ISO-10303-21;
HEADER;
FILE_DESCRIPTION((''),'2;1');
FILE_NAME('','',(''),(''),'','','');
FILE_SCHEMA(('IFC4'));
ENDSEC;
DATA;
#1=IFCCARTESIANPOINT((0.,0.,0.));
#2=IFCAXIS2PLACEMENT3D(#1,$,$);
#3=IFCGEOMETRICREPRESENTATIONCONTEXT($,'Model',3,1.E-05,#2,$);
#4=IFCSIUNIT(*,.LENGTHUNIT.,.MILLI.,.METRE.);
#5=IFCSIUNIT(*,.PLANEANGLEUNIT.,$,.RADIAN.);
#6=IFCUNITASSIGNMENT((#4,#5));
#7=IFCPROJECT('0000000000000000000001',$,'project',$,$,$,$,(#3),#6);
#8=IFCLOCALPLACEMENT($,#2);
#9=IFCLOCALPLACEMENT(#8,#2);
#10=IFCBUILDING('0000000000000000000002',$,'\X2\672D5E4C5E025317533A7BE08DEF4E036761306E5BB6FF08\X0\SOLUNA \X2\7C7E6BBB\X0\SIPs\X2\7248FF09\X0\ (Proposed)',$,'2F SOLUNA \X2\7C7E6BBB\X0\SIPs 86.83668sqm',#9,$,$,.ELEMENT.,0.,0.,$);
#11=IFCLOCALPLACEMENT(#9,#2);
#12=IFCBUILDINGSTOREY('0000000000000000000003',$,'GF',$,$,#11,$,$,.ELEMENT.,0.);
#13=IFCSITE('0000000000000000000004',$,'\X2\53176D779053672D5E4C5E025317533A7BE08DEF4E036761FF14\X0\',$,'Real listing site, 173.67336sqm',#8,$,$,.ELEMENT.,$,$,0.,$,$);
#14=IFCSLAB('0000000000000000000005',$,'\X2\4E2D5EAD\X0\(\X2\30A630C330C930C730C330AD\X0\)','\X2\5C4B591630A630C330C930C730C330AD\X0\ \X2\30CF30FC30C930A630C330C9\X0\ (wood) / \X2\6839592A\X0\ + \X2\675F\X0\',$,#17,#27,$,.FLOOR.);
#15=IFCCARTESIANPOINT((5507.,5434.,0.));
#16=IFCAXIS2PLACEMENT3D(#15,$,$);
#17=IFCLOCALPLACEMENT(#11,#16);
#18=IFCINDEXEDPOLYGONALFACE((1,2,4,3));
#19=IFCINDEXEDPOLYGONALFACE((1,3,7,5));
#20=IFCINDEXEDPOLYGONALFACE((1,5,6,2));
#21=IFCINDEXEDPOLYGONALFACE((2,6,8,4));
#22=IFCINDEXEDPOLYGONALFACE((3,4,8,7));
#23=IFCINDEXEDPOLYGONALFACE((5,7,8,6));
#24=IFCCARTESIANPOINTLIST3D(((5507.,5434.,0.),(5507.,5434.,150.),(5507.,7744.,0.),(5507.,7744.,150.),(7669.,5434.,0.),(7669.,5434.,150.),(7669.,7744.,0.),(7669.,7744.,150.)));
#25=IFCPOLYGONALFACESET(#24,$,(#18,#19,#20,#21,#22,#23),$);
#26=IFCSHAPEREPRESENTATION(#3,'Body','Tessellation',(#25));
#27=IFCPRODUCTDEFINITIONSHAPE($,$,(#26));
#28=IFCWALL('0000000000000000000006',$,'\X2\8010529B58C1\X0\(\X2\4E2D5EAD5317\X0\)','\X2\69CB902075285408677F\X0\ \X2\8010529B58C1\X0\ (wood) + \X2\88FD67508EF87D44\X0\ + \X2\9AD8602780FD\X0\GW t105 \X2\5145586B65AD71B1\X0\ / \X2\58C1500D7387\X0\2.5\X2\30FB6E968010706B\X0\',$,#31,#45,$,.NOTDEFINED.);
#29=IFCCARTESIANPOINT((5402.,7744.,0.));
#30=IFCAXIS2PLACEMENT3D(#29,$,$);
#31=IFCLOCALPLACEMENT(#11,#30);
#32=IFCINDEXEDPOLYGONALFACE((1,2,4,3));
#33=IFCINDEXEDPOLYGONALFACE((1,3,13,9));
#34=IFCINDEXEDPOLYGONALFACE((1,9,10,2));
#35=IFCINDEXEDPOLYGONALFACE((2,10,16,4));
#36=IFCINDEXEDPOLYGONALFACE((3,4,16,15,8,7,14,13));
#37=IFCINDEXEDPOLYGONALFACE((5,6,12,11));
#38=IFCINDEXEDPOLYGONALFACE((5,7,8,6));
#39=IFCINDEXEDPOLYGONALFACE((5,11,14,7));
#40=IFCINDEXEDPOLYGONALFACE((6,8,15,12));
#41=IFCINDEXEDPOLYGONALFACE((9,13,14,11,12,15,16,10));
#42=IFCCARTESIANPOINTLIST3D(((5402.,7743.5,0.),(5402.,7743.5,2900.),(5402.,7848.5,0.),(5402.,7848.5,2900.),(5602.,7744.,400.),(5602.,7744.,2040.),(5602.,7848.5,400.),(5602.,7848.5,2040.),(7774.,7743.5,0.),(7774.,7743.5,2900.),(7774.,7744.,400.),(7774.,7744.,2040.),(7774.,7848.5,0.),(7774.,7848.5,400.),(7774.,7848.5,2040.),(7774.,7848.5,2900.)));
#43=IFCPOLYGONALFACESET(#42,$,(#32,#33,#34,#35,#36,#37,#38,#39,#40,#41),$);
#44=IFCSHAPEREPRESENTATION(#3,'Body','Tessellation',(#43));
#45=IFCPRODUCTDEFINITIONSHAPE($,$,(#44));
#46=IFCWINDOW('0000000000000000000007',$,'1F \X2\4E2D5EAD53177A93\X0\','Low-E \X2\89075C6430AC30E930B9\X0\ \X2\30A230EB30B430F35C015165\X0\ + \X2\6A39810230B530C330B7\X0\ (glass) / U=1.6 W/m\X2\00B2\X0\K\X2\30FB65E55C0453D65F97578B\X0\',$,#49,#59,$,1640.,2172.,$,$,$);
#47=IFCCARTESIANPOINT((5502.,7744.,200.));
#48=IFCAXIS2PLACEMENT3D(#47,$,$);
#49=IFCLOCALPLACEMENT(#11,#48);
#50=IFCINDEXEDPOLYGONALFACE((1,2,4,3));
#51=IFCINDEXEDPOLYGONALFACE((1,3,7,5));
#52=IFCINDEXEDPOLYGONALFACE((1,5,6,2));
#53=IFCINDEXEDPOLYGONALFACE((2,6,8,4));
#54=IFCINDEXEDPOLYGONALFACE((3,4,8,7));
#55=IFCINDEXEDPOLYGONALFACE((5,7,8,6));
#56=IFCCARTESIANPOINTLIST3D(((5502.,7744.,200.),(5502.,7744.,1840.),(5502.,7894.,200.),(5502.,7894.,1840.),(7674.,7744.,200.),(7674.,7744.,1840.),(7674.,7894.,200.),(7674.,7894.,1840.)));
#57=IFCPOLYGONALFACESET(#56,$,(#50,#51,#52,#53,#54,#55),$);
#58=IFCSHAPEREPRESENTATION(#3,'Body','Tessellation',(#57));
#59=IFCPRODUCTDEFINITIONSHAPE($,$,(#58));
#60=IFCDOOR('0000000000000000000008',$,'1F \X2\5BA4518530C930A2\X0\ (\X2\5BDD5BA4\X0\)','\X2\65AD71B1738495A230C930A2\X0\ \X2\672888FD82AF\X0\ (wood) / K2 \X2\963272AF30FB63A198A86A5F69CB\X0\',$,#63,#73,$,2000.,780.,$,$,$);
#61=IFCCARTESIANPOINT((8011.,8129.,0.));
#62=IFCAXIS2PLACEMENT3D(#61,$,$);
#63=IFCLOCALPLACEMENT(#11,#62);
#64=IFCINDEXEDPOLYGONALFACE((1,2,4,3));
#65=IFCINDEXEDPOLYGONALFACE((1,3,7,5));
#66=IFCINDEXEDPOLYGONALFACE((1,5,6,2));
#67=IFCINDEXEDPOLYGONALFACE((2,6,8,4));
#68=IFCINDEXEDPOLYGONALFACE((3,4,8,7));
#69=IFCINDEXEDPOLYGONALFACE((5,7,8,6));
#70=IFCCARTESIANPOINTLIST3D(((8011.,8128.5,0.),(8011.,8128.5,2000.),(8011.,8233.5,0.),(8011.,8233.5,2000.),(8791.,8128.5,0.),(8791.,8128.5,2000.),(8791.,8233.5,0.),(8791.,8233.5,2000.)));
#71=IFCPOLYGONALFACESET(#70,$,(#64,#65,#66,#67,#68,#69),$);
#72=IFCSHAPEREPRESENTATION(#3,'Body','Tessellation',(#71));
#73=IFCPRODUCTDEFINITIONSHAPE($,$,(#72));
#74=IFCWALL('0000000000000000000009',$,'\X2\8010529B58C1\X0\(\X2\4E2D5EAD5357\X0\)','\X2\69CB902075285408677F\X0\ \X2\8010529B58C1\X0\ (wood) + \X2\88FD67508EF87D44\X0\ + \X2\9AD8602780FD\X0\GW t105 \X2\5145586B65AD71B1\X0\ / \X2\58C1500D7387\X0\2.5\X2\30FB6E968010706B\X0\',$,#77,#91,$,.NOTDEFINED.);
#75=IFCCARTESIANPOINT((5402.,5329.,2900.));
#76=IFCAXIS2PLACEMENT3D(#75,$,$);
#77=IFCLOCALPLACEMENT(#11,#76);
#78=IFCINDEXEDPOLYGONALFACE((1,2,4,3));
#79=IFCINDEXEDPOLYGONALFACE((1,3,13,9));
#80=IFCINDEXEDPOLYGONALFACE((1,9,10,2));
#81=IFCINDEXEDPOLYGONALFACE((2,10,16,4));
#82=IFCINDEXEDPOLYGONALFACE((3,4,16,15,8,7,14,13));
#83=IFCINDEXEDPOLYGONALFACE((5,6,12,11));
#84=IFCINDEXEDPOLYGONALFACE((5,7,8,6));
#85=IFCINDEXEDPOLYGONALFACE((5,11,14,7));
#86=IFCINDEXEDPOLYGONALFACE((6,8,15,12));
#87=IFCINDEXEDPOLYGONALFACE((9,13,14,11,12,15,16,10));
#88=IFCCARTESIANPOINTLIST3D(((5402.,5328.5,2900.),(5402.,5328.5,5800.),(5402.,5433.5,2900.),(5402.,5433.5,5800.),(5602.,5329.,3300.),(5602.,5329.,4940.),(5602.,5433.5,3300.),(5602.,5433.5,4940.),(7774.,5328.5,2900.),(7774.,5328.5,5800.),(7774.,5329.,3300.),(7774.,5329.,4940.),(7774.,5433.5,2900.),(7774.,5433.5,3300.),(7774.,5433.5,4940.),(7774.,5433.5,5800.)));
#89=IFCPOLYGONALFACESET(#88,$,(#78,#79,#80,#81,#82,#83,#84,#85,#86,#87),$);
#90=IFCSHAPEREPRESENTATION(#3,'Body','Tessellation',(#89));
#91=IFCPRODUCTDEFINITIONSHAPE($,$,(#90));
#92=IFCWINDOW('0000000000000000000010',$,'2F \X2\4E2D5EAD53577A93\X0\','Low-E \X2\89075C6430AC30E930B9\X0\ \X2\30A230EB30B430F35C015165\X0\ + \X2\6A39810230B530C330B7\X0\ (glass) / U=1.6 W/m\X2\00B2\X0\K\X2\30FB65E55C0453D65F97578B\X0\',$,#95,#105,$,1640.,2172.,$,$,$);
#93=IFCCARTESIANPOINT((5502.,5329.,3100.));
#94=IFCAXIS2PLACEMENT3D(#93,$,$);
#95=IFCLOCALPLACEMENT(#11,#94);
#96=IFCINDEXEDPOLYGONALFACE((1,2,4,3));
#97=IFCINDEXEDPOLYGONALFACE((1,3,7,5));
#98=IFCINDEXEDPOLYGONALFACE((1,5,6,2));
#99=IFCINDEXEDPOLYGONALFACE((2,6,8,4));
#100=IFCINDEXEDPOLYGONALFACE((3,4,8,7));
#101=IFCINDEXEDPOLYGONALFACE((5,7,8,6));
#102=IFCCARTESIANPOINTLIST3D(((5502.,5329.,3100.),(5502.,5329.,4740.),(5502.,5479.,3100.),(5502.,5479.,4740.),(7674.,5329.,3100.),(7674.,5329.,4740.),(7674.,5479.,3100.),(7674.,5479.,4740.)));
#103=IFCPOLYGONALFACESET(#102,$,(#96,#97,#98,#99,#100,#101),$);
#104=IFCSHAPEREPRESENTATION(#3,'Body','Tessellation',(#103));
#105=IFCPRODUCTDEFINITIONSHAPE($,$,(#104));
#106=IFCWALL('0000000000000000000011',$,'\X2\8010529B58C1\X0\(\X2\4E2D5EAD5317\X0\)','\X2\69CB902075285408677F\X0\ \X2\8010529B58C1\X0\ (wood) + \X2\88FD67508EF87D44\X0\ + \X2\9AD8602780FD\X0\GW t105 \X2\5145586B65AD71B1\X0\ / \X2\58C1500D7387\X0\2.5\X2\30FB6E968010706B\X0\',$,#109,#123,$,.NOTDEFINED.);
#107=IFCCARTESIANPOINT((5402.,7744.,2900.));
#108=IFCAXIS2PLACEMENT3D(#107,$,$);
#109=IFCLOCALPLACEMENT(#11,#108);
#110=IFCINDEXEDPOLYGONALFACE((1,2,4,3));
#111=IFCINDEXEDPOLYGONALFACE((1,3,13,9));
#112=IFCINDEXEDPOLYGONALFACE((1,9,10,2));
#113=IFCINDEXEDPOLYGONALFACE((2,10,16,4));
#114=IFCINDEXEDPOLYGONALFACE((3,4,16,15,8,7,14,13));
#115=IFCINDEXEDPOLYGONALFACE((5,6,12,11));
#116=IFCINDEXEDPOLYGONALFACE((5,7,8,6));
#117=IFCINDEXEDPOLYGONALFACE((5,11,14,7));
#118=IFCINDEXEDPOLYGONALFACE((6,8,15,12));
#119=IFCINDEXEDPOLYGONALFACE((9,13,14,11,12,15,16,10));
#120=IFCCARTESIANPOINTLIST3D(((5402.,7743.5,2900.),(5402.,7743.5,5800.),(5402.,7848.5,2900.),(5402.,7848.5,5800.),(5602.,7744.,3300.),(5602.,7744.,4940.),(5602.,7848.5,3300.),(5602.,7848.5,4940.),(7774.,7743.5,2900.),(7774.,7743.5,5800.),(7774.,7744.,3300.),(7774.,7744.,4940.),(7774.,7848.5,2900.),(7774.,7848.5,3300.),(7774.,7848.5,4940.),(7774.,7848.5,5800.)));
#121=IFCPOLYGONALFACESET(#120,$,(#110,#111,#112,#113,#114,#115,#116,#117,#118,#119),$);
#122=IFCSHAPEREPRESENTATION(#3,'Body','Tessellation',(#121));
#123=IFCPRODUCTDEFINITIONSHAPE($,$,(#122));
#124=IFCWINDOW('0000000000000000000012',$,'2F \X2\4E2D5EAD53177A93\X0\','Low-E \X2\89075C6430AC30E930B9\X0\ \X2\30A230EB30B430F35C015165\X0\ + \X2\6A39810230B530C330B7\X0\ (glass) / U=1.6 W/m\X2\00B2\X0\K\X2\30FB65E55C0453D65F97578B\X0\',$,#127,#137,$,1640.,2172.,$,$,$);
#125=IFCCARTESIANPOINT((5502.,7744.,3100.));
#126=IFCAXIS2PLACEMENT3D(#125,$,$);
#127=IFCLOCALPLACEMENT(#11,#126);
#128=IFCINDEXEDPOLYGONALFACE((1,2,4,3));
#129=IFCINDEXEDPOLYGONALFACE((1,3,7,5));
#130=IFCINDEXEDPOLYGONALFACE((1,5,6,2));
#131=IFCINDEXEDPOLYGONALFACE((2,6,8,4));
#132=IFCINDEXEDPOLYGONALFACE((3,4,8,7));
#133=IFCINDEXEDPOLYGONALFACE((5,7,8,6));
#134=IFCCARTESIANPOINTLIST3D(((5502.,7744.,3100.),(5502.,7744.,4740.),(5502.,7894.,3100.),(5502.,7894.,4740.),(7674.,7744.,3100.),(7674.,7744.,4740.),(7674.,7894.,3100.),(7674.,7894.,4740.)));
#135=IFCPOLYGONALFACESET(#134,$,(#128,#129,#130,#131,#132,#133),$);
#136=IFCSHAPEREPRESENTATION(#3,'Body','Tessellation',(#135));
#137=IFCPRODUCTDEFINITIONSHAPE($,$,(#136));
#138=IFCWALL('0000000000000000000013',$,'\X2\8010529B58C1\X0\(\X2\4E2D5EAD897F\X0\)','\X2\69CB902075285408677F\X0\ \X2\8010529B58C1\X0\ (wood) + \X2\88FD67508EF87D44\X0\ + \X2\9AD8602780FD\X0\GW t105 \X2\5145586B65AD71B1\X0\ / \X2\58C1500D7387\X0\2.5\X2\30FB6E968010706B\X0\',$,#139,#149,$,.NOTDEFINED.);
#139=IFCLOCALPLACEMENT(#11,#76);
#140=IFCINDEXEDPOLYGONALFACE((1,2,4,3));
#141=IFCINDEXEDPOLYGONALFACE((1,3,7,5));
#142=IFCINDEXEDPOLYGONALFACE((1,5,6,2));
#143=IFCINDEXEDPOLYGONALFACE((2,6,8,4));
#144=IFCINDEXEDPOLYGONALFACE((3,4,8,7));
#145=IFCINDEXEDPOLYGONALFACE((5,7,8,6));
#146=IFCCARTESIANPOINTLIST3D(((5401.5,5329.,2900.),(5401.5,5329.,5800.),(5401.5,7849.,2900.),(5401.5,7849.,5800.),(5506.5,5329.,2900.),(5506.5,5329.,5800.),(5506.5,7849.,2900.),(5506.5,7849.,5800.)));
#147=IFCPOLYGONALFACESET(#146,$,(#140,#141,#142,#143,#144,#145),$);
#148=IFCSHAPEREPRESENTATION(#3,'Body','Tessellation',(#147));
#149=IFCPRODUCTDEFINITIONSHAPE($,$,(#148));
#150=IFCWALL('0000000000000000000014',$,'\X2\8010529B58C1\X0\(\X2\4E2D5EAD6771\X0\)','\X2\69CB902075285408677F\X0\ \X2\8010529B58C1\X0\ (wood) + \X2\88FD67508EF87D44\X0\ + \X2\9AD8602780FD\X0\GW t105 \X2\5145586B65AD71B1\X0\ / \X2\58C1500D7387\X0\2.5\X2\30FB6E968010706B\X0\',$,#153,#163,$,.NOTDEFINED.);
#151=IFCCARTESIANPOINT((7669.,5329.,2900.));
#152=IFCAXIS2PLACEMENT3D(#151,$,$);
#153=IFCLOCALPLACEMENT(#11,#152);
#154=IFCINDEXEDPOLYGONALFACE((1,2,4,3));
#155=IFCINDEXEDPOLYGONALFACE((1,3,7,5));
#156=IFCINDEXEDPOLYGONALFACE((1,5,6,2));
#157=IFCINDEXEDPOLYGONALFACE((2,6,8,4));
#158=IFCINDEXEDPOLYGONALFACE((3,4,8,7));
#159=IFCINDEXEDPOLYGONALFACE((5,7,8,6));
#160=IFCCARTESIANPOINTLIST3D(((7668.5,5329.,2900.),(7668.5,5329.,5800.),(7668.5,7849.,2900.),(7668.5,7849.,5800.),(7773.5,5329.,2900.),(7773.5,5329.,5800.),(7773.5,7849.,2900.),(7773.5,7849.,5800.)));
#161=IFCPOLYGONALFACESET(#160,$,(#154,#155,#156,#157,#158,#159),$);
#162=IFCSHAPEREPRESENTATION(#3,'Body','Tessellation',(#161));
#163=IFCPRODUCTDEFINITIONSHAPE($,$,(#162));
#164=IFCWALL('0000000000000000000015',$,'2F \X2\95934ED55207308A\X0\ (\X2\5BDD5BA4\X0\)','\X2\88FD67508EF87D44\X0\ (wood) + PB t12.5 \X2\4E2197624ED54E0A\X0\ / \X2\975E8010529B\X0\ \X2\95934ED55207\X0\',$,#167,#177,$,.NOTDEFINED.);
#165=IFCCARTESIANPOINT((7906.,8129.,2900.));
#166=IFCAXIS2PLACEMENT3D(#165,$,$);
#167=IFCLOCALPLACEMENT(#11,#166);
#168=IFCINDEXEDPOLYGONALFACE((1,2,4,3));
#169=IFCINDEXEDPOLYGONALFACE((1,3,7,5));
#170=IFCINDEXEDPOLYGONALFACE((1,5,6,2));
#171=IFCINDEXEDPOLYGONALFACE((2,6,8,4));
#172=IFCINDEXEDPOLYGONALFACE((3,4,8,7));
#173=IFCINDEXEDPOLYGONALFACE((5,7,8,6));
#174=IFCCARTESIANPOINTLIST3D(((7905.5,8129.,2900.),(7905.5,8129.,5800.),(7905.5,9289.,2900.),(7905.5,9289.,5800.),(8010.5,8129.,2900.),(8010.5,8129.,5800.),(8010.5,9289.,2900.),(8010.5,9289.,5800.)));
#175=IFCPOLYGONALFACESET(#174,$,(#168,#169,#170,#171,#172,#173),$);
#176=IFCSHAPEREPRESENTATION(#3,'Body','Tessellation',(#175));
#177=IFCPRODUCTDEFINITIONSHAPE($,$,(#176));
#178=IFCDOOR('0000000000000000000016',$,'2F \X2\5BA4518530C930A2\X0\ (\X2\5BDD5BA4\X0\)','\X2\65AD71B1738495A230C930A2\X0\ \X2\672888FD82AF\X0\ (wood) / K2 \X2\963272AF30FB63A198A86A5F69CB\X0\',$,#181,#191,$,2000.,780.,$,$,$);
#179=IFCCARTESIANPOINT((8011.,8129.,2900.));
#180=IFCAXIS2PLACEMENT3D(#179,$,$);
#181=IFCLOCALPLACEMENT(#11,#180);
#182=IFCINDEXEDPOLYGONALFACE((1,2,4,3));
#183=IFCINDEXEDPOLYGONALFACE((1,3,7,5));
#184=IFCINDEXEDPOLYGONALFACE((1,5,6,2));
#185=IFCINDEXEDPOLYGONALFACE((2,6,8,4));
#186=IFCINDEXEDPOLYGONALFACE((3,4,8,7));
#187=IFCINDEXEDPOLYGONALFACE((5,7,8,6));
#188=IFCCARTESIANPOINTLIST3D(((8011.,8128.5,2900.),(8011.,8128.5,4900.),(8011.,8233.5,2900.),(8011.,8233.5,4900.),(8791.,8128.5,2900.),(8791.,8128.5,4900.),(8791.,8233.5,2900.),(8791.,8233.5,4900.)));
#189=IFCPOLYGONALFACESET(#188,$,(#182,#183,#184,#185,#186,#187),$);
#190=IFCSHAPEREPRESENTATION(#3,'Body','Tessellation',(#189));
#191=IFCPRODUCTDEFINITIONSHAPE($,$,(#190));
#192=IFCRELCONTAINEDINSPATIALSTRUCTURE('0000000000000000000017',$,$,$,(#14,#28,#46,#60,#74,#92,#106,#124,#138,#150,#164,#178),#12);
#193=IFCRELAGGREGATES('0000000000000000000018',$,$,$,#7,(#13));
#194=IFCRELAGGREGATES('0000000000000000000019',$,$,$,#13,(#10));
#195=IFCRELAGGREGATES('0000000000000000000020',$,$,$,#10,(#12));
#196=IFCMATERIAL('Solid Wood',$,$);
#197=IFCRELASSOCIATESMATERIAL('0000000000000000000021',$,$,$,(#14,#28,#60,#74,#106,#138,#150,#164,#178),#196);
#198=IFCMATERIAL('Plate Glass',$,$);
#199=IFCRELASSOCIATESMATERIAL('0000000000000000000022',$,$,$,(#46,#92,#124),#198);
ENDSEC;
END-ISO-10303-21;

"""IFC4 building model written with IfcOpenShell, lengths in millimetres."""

from ifc_helpers import new_model, si_unit, frame, frame_2d, origin, place, context, project, spatial, rectangle, extrude, material, element, fill, save


model = new_model("IFC4")

# Units and contexts
model_context = context("Model", 3, precision=1e-05, world=origin())
ifc_project = project(units=[si_unit("LENGTHUNIT", "METRE", prefix="MILLI"), si_unit("PLANEANGLEUNIT", "RADIAN")], contexts=[model_context])

# Site, building, storey
site_placement = place(None, origin())
site = spatial("IfcSite", under=ifc_project, at=site_placement, Name="北海道札幌市北区篠路七条４", ObjectType="Real listing site, 173.67336sqm", CompositionType="ELEMENT", RefElevation=0.0)
building_placement = place(site_placement, origin())
building = spatial("IfcBuilding", under=site, at=building_placement, Name="札幌市北区篠路七条の家（SOLUNA 籾殻SIPs版） (Proposed)", ObjectType="2F SOLUNA 籾殻SIPs 86.83668sqm", CompositionType="ELEMENT", ElevationOfRefHeight=0.0, ElevationOfTerrain=0.0)
storey_placement = place(building_placement, origin())
storey = spatial("IfcBuildingStorey", under=building, at=storey_placement, Name="GF", CompositionType="ELEMENT", Elevation=0.0)

# Slab
ifc_material_1 = material(Name="Solid Wood")
slab_placement = place(storey_placement, frame((5507.0, 5434.0, 0.0)))
element("IfcSlab", 1, at=slab_placement, inside=storey, material=ifc_material_1, Name="中庭(ウッドデッキ)", Description="屋外ウッドデッキ ハードウッド (wood) / 根太 + 束", PredefinedType="FLOOR", context=model_context, shape_type="SweptSolid", body=[
    extrude(rectangle(XDim=2162.0, YDim=2310.0, at=frame_2d((1081.0, 1155.0))), frame((5507.0, 5434.0, 0.0)), (0.0, 0.0, 1.0), 150.0),
])

# Wall, opening, window
wall_1_placement = place(storey_placement, frame((5402.0, 7744.0, 0.0)))
wall_1 = element("IfcWall", 2, at=wall_1_placement, inside=storey, material=ifc_material_1, Name="耐力壁(中庭北)", Description="構造用合板 耐力壁 (wood) + 製材軸組 + 高性能GW t105 充填断熱 / 壁倍率2.5・準耐火", PredefinedType="NOTDEFINED", context=model_context, shape_type="SweptSolid", body=[
    extrude(rectangle(XDim=2372.0, YDim=105.0, at=frame_2d((1186.0, 52.0))), frame((5402.0, 7744.0, 0.0)), (0.0, 0.0, 1.0), 2900.0),
])
opening_1_placement = place(storey_placement, frame((5502.0, 7744.0, 200.0)))
opening_1 = element("IfcOpeningElement", 3, at=opening_1_placement, cuts=wall_1, PredefinedType="NOTDEFINED", context=model_context, shape_type="SweptSolid", body=[
    extrude(rectangle(XDim=2172.0, YDim=150.0, at=frame_2d((1086.0, 75.0))), frame((5502.0, 7744.0, 200.0)), (0.0, 0.0, 1.0), 1640.0),
])
ifc_material_2 = material(Name="Plate Glass")
window_1_placement = place(storey_placement, frame((5502.0, 7744.0, 200.0)))
window_1 = element("IfcWindow", 4, at=window_1_placement, inside=storey, material=ifc_material_2, Name="1F 中庭北窓", Description="Low-E 複層ガラス アルゴン封入 + 樹脂サッシ (glass) / U=1.6 W/m²K・日射取得型", OverallHeight=1640.0, OverallWidth=2172.0, context=model_context, shape_type="SweptSolid", body=[
    extrude(rectangle(XDim=2172.0, YDim=150.0, at=frame_2d((1086.0, 75.0))), frame((5502.0, 7744.0, 200.0)), (0.0, 0.0, 1.0), 1640.0),
])
fill(opening_1, window_1)

# Door
door_1_placement = place(storey_placement, frame((8011.0, 8129.0, 0.0)))
element("IfcDoor", 5, at=door_1_placement, inside=storey, material=ifc_material_1, Name="1F 室内ドア (寝室)", Description="断熱玄関ドア 木製芯 (wood) / K2 防犯・採風機構", OverallHeight=2000.0, OverallWidth=780.0, context=model_context, shape_type="SweptSolid", body=[
    extrude(rectangle(XDim=780.0, YDim=105.0, at=frame_2d((390.0, 52.0))), frame((8011.0, 8129.0, 0.0)), (0.0, 0.0, 1.0), 2000.0),
])

# Walls, openings, windows
wall_2_placement = place(storey_placement, frame((5402.0, 5329.0, 2900.0)))
wall_2 = element("IfcWall", 6, at=wall_2_placement, inside=storey, material=ifc_material_1, Name="耐力壁(中庭南)", Description="構造用合板 耐力壁 (wood) + 製材軸組 + 高性能GW t105 充填断熱 / 壁倍率2.5・準耐火", PredefinedType="NOTDEFINED", context=model_context, shape_type="SweptSolid", body=[
    extrude(rectangle(XDim=2372.0, YDim=105.0, at=frame_2d((1186.0, 52.0))), frame((5402.0, 5329.0, 2900.0)), (0.0, 0.0, 1.0), 2900.0),
])
opening_2_placement = place(storey_placement, frame((5502.0, 5329.0, 3100.0)))
opening_2 = element("IfcOpeningElement", 7, at=opening_2_placement, cuts=wall_2, PredefinedType="NOTDEFINED", context=model_context, shape_type="SweptSolid", body=[
    extrude(rectangle(XDim=2172.0, YDim=150.0, at=frame_2d((1086.0, 75.0))), frame((5502.0, 5329.0, 3100.0)), (0.0, 0.0, 1.0), 1640.0),
])
window_2_placement = place(storey_placement, frame((5502.0, 5329.0, 3100.0)))
window_2 = element("IfcWindow", 8, at=window_2_placement, inside=storey, material=ifc_material_2, Name="2F 中庭南窓", Description="Low-E 複層ガラス アルゴン封入 + 樹脂サッシ (glass) / U=1.6 W/m²K・日射取得型", OverallHeight=1640.0, OverallWidth=2172.0, context=model_context, shape_type="SweptSolid", body=[
    extrude(rectangle(XDim=2172.0, YDim=150.0, at=frame_2d((1086.0, 75.0))), frame((5502.0, 5329.0, 3100.0)), (0.0, 0.0, 1.0), 1640.0),
])
fill(opening_2, window_2)
wall_3_placement = place(storey_placement, frame((5402.0, 7744.0, 2900.0)))
wall_3 = element("IfcWall", 9, at=wall_3_placement, inside=storey, material=ifc_material_1, Name="耐力壁(中庭北)", Description="構造用合板 耐力壁 (wood) + 製材軸組 + 高性能GW t105 充填断熱 / 壁倍率2.5・準耐火", PredefinedType="NOTDEFINED", context=model_context, shape_type="SweptSolid", body=[
    extrude(rectangle(XDim=2372.0, YDim=105.0, at=frame_2d((1186.0, 52.0))), frame((5402.0, 7744.0, 2900.0)), (0.0, 0.0, 1.0), 2900.0),
])
opening_3_placement = place(storey_placement, frame((5502.0, 7744.0, 3100.0)))
opening_3 = element("IfcOpeningElement", 10, at=opening_3_placement, cuts=wall_3, PredefinedType="NOTDEFINED", context=model_context, shape_type="SweptSolid", body=[
    extrude(rectangle(XDim=2172.0, YDim=150.0, at=frame_2d((1086.0, 75.0))), frame((5502.0, 7744.0, 3100.0)), (0.0, 0.0, 1.0), 1640.0),
])
window_3_placement = place(storey_placement, frame((5502.0, 7744.0, 3100.0)))
window_3 = element("IfcWindow", 11, at=window_3_placement, inside=storey, material=ifc_material_2, Name="2F 中庭北窓", Description="Low-E 複層ガラス アルゴン封入 + 樹脂サッシ (glass) / U=1.6 W/m²K・日射取得型", OverallHeight=1640.0, OverallWidth=2172.0, context=model_context, shape_type="SweptSolid", body=[
    extrude(rectangle(XDim=2172.0, YDim=150.0, at=frame_2d((1086.0, 75.0))), frame((5502.0, 7744.0, 3100.0)), (0.0, 0.0, 1.0), 1640.0),
])
fill(opening_3, window_3)

# Walls
wall_4_placement = place(storey_placement, frame((5402.0, 5329.0, 2900.0)))
element("IfcWall", 12, at=wall_4_placement, inside=storey, material=ifc_material_1, Name="耐力壁(中庭西)", Description="構造用合板 耐力壁 (wood) + 製材軸組 + 高性能GW t105 充填断熱 / 壁倍率2.5・準耐火", PredefinedType="NOTDEFINED", context=model_context, shape_type="SweptSolid", body=[
    extrude(rectangle(XDim=105.0, YDim=2520.0, at=frame_2d((52.0, 1260.0))), frame((5402.0, 5329.0, 2900.0)), (0.0, 0.0, 1.0), 2900.0),
])
wall_5_placement = place(storey_placement, frame((7669.0, 5329.0, 2900.0)))
element("IfcWall", 13, at=wall_5_placement, inside=storey, material=ifc_material_1, Name="耐力壁(中庭東)", Description="構造用合板 耐力壁 (wood) + 製材軸組 + 高性能GW t105 充填断熱 / 壁倍率2.5・準耐火", PredefinedType="NOTDEFINED", context=model_context, shape_type="SweptSolid", body=[
    extrude(rectangle(XDim=105.0, YDim=2520.0, at=frame_2d((52.0, 1260.0))), frame((7669.0, 5329.0, 2900.0)), (0.0, 0.0, 1.0), 2900.0),
])
wall_6_placement = place(storey_placement, frame((7906.0, 8129.0, 2900.0)))
element("IfcWall", 14, at=wall_6_placement, inside=storey, material=ifc_material_1, Name="2F 間仕切り (寝室)", Description="製材軸組 (wood) + PB t12.5 両面仕上 / 非耐力 間仕切", PredefinedType="NOTDEFINED", context=model_context, shape_type="SweptSolid", body=[
    extrude(rectangle(XDim=105.0, YDim=1160.0, at=frame_2d((52.0, 580.0))), frame((7906.0, 8129.0, 2900.0)), (0.0, 0.0, 1.0), 2900.0),
])

# Door
door_2_placement = place(storey_placement, frame((8011.0, 8129.0, 2900.0)))
element("IfcDoor", 15, at=door_2_placement, inside=storey, material=ifc_material_1, Name="2F 室内ドア (寝室)", Description="断熱玄関ドア 木製芯 (wood) / K2 防犯・採風機構", OverallHeight=2000.0, OverallWidth=780.0, context=model_context, shape_type="SweptSolid", body=[
    extrude(rectangle(XDim=780.0, YDim=105.0, at=frame_2d((390.0, 52.0))), frame((8011.0, 8129.0, 2900.0)), (0.0, 0.0, 1.0), 2000.0),
])

save(model, "model.ifc")
